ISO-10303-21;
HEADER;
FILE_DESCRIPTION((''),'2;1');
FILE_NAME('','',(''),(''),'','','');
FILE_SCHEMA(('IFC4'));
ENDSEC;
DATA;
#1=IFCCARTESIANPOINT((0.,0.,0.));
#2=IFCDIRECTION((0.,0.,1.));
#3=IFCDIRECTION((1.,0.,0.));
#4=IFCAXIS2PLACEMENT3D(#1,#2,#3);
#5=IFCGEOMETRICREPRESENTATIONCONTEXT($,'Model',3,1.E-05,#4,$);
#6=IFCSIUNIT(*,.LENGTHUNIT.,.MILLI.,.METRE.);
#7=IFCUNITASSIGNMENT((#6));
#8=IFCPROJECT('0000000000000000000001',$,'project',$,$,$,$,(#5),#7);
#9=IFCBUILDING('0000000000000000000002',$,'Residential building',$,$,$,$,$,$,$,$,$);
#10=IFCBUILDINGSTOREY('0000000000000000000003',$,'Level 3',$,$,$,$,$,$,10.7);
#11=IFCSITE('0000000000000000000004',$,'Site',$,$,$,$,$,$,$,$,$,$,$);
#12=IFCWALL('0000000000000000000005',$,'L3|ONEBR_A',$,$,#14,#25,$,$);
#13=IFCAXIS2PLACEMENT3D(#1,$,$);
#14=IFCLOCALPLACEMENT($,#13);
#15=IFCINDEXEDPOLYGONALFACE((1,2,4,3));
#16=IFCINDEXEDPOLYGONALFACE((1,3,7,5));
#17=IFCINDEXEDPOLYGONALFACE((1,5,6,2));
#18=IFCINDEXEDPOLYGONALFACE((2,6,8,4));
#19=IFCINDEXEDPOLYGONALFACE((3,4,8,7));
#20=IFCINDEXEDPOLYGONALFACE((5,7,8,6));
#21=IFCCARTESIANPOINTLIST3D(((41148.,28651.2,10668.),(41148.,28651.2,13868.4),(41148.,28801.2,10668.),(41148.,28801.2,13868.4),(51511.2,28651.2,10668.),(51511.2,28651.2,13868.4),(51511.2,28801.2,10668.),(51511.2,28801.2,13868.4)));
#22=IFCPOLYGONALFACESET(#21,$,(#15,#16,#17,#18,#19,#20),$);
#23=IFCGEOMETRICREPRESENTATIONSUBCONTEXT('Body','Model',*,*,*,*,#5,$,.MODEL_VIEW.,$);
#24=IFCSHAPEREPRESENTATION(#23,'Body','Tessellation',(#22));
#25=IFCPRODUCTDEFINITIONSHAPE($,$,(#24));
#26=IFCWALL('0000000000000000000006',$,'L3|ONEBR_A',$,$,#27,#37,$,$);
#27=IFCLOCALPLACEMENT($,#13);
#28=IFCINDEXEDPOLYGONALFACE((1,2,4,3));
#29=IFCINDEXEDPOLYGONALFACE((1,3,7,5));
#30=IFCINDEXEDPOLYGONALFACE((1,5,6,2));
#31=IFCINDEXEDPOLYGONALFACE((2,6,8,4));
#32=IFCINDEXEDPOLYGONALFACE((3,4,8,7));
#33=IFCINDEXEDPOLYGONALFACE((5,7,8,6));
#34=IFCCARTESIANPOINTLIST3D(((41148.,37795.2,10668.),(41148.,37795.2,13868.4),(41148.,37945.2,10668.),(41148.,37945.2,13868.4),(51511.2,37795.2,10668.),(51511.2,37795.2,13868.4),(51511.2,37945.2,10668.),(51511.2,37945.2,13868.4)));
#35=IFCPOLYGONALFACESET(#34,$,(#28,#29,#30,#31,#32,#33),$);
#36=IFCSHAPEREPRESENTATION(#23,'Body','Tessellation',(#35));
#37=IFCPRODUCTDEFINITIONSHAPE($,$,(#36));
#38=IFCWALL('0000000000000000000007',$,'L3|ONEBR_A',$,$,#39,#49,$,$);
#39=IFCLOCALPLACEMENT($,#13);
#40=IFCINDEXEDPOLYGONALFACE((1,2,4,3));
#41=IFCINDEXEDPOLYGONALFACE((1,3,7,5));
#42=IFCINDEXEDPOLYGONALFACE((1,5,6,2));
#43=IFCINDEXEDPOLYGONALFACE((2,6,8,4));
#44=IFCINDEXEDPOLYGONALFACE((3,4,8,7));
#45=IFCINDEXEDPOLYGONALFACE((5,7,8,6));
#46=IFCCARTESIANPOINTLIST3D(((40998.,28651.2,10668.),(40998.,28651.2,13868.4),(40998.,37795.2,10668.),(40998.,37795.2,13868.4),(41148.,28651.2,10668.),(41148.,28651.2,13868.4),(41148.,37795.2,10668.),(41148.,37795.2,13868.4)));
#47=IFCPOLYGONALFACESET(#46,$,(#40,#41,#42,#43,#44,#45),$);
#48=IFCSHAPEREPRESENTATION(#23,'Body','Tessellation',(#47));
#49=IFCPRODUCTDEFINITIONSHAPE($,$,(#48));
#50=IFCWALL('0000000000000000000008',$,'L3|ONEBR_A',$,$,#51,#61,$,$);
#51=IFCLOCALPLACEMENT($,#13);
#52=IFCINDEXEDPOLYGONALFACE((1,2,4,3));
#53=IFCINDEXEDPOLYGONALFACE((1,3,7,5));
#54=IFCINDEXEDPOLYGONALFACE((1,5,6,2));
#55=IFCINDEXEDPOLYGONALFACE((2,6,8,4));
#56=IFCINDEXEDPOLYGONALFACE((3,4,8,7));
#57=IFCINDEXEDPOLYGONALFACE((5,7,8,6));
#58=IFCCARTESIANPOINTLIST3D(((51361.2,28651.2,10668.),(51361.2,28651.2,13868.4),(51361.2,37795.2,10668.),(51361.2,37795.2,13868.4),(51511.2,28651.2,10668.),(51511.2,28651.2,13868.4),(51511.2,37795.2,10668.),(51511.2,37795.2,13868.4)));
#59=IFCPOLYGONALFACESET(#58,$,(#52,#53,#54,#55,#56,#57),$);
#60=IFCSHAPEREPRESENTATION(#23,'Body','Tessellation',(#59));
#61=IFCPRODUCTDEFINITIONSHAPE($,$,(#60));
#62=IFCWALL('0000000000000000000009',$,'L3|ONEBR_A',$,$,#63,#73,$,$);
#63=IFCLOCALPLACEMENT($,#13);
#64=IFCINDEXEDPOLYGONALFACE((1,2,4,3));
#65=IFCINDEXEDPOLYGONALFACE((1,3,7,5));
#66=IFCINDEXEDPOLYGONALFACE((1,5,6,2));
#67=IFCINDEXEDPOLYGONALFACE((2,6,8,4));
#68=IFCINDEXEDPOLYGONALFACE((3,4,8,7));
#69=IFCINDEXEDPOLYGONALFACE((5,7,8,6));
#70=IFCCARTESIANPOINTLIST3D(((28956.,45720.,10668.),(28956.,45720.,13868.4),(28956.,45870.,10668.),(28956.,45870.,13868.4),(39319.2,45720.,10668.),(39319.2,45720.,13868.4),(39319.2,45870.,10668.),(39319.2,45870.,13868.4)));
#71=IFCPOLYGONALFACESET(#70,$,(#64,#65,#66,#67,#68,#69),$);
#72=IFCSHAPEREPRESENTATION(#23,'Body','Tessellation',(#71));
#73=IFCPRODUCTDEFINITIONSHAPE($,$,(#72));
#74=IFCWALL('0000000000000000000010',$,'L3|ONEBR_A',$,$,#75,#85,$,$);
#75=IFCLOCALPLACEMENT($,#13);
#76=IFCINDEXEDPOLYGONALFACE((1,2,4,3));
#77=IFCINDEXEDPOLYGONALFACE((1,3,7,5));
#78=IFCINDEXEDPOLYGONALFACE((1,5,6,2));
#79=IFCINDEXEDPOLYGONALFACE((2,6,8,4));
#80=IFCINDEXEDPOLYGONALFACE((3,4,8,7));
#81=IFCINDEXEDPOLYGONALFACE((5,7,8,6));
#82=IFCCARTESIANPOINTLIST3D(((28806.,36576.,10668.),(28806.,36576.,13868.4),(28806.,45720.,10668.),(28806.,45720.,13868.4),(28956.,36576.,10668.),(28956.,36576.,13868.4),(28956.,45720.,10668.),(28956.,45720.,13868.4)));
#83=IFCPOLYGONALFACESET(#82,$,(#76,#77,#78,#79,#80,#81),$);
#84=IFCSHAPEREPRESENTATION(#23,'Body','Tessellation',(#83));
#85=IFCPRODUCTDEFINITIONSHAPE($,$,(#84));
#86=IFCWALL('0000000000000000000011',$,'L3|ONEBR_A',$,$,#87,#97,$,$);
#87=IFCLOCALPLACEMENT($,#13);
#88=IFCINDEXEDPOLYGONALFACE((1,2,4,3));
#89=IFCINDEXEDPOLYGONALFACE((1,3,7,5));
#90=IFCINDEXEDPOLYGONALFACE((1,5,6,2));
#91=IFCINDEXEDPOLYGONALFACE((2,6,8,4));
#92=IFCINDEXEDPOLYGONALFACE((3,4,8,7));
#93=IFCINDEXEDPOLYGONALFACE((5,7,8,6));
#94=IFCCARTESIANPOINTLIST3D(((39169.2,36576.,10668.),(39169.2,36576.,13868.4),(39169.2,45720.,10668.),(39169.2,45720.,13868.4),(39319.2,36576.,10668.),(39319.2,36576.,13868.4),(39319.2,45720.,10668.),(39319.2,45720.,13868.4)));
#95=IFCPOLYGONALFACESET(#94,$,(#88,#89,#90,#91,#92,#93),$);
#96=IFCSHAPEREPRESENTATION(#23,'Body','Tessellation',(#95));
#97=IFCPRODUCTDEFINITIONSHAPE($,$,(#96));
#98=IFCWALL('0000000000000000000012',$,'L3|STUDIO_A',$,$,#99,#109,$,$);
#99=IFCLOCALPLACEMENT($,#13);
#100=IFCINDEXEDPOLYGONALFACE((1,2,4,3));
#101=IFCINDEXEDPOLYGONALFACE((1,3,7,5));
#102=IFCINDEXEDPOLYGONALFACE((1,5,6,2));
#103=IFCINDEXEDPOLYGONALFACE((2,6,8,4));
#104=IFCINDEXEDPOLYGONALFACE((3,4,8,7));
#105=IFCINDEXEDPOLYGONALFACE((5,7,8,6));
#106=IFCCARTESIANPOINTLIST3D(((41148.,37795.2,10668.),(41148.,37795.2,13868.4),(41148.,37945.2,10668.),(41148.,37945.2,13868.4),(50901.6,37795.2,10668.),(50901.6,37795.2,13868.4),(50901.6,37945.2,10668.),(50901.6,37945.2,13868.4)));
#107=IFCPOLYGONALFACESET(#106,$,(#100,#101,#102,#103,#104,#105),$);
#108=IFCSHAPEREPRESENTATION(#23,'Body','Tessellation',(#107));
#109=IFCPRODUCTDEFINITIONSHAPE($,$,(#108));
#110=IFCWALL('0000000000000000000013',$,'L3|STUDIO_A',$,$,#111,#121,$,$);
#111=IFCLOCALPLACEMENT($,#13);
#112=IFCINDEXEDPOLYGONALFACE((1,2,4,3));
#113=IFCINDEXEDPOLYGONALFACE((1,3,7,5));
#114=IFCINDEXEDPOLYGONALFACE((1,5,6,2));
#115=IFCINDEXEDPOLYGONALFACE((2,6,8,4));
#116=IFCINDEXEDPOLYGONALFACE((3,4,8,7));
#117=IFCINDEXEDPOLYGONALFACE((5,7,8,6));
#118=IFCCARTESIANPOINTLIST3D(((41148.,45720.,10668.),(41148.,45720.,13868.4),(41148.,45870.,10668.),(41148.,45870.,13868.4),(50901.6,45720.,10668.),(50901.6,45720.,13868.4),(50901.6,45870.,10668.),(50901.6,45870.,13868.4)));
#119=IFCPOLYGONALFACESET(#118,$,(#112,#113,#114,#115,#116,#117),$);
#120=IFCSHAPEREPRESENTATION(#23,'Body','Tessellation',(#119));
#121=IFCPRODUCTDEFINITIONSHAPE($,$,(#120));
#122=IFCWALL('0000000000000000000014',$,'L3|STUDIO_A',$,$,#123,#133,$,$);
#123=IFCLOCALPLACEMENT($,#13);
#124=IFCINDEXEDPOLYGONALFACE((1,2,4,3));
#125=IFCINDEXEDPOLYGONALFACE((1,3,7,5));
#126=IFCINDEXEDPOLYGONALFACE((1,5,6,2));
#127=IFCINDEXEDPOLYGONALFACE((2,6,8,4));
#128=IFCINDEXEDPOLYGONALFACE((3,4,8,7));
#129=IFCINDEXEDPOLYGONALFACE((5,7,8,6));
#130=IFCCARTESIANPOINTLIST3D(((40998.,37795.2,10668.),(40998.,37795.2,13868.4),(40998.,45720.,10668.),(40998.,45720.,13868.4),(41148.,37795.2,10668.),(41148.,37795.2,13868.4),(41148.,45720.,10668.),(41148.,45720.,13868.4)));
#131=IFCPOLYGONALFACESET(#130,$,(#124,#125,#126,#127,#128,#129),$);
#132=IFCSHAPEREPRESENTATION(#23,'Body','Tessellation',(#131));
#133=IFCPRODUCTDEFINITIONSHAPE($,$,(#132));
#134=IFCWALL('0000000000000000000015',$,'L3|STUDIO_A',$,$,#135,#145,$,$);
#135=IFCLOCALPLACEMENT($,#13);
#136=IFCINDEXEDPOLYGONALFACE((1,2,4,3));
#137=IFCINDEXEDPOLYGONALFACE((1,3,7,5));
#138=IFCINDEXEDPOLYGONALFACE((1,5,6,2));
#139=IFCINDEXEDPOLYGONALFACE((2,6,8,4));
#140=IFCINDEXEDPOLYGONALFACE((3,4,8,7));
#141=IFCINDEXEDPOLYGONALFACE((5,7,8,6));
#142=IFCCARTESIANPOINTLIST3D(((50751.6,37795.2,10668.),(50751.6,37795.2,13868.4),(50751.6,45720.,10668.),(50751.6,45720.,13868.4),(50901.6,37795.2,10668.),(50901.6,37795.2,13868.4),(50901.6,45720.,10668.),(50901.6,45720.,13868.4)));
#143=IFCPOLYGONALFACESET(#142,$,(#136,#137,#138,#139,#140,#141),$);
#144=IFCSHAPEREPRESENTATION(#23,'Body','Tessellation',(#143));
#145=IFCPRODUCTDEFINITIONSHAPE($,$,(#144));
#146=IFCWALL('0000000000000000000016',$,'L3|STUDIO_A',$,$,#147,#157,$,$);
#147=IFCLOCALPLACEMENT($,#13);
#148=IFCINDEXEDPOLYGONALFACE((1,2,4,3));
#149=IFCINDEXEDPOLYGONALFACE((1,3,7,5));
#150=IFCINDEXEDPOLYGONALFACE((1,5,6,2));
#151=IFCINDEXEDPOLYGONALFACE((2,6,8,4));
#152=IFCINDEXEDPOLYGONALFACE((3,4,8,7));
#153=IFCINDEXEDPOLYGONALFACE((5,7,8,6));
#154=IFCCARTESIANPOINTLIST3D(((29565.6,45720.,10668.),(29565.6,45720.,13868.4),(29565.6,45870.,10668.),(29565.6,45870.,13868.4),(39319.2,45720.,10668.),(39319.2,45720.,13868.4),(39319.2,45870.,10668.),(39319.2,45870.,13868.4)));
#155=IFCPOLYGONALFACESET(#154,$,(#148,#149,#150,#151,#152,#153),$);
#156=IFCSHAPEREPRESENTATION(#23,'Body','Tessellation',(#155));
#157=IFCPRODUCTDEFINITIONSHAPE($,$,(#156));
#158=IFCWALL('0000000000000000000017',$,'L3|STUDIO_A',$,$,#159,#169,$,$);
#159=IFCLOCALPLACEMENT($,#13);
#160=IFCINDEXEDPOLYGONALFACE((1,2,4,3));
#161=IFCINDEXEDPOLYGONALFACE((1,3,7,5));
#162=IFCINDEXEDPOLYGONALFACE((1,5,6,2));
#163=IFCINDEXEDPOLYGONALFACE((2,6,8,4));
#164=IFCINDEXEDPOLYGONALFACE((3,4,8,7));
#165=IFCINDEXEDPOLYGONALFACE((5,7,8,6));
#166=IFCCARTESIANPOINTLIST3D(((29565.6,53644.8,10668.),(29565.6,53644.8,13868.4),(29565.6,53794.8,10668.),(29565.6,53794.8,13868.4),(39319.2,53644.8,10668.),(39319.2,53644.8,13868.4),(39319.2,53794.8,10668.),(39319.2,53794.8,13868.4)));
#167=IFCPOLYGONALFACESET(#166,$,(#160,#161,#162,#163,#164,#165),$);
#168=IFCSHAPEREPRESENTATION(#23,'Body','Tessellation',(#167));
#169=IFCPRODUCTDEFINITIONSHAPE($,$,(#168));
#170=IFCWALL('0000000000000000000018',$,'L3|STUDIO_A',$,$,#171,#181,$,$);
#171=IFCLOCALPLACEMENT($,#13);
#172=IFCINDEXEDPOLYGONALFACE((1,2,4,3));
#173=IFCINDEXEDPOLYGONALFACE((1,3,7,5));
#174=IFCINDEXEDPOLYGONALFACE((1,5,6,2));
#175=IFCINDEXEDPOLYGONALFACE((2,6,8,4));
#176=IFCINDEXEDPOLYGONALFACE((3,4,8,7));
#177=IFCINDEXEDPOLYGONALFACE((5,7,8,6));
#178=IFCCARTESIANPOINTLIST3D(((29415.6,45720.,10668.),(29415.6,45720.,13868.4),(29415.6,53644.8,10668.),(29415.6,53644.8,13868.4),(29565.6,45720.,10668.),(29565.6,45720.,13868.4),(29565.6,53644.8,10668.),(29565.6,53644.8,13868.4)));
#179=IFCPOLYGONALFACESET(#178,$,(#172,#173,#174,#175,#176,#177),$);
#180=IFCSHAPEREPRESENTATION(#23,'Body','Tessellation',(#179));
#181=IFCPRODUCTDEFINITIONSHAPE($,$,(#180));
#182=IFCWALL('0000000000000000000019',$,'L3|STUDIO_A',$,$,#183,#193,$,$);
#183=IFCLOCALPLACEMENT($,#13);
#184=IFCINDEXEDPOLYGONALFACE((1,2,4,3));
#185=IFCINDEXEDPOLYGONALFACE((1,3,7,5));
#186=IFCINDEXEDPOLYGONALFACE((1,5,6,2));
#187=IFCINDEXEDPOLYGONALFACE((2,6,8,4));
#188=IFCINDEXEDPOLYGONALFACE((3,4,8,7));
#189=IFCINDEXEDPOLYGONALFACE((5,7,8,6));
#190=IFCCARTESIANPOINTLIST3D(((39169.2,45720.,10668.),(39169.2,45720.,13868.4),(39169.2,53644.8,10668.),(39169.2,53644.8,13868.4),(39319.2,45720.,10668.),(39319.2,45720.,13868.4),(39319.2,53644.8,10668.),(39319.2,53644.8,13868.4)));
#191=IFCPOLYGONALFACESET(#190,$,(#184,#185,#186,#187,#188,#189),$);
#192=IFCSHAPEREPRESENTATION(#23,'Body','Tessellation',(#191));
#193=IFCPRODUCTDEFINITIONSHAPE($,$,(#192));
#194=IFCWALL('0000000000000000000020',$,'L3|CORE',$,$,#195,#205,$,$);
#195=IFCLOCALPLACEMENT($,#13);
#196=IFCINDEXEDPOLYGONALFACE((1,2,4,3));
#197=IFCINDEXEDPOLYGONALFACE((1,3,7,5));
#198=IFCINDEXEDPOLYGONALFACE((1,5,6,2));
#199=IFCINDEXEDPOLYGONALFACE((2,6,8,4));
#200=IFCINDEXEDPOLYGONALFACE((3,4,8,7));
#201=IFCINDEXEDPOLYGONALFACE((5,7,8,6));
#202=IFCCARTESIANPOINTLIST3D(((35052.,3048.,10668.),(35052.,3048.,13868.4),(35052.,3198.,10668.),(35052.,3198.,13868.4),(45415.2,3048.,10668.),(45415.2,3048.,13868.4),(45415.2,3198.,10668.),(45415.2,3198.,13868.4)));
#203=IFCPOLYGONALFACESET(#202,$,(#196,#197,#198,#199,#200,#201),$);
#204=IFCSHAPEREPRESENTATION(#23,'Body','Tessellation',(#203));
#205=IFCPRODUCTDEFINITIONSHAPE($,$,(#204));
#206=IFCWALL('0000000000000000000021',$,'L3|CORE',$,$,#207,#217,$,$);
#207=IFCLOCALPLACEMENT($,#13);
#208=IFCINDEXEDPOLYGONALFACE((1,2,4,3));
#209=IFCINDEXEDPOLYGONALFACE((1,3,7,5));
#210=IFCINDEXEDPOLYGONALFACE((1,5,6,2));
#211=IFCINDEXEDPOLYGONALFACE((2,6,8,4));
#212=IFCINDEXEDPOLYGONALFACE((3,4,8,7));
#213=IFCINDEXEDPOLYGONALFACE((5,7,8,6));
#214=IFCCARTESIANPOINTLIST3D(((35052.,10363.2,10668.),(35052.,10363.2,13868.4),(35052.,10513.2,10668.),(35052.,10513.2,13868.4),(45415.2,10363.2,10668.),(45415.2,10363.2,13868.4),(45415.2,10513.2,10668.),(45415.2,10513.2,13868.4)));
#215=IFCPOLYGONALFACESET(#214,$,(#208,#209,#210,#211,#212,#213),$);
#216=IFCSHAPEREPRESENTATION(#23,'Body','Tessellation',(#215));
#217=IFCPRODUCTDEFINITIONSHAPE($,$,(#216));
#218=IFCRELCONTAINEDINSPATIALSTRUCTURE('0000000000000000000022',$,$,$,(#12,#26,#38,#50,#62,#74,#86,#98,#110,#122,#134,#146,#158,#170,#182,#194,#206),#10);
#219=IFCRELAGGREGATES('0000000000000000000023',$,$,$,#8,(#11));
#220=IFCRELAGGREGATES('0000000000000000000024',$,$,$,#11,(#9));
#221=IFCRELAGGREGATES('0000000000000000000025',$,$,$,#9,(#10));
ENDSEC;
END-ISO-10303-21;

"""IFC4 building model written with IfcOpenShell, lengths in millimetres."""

from ifc_helpers import new_model, si_unit, frame, origin_with_axes, place, context, subcontext, project, spatial, indexed_curve, outline, extrude, element, save


model = new_model("IFC4")

# Units and contexts
model_context = context("Model", 3, precision=1e-05, world=origin_with_axes())
body_context = subcontext(model_context, "Body", "Model", "MODEL_VIEW")
ifc_project = project(units=[si_unit("LENGTHUNIT", "METRE", prefix="MILLI")], contexts=[model_context])

# Site, building, storey
site = spatial("IfcSite", under=ifc_project, Name="Site")
building = spatial("IfcBuilding", under=site, Name="Residential building")
storey = spatial("IfcBuildingStorey", under=building, Name="Level 3", Elevation=10.7)

# Walls
for number, where, z_axis, x_axis, name in (
    (1, (41148.0, 28651.2, 10668.0), (0.0, 0.0, 1.0), (1.0, 0.0, 0.0), "L3|ONEBR_A"),
    (2, (41148.0, 37795.2, 10668.0), (0.0, 0.0, 1.0), (1.0, 0.0, 0.0), "L3|ONEBR_A"),
):
    element("IfcWall", number, at=place(None, frame(where, z_axis=z_axis, x_axis=x_axis)), inside=storey, Name=name, context=body_context, shape_type="SweptSolid", body=[
        extrude(outline(indexed_curve([(0.0, 0.0), (0.0, 150.0), (10363.2, 150.0), (10363.2, 0.0), (0.0, 0.0)], self_intersect=False)), origin_with_axes(), (0.0, 0.0, 1.0), 3200.4),
    ])
for number, where, z_axis, x_axis, name in (
    (3, (41148.0, 28651.2, 10668.0), (0.0, 0.0, 1.0), (0.0, 1.0, 0.0), "L3|ONEBR_A"),
    (4, (51511.2, 28651.2, 10668.0), (0.0, 0.0, 1.0), (0.0, 1.0, 0.0), "L3|ONEBR_A"),
):
    element("IfcWall", number, at=place(None, frame(where, z_axis=z_axis, x_axis=x_axis)), inside=storey, Name=name, context=body_context, shape_type="SweptSolid", body=[
        extrude(outline(indexed_curve([(0.0, 0.0), (0.0, 150.0), (9144.0, 150.0), (9144.0, 0.0), (0.0, 0.0)], self_intersect=False)), origin_with_axes(), (0.0, 0.0, 1.0), 3200.4),
    ])
for number, where, z_axis, x_axis, name in (
    (5, (28956.0, 45720.0, 10668.0), (0.0, 0.0, 1.0), (1.0, 0.0, 0.0), "L3|ONEBR_A"),
):
    element("IfcWall", number, at=place(None, frame(where, z_axis=z_axis, x_axis=x_axis)), inside=storey, Name=name, context=body_context, shape_type="SweptSolid", body=[
        extrude(outline(indexed_curve([(0.0, 0.0), (0.0, 150.0), (10363.2, 150.0), (10363.2, 0.0), (0.0, 0.0)], self_intersect=False)), origin_with_axes(), (0.0, 0.0, 1.0), 3200.4),
    ])
for number, where, z_axis, x_axis, name in (
    (6, (28956.0, 36576.0, 10668.0), (0.0, 0.0, 1.0), (0.0, 1.0, 0.0), "L3|ONEBR_A"),
    (7, (39319.2, 36576.0, 10668.0), (0.0, 0.0, 1.0), (0.0, 1.0, 0.0), "L3|ONEBR_A"),
):
    element("IfcWall", number, at=place(None, frame(where, z_axis=z_axis, x_axis=x_axis)), inside=storey, Name=name, context=body_context, shape_type="SweptSolid", body=[
        extrude(outline(indexed_curve([(0.0, 0.0), (0.0, 150.0), (9144.0, 150.0), (9144.0, 0.0), (0.0, 0.0)], self_intersect=False)), origin_with_axes(), (0.0, 0.0, 1.0), 3200.4),
    ])
for number, where, z_axis, x_axis, name in (
    (8, (41148.0, 37795.2, 10668.0), (0.0, 0.0, 1.0), (1.0, 0.0, 0.0), "L3|STUDIO_A"),
    (9, (41148.0, 45720.0, 10668.0), (0.0, 0.0, 1.0), (1.0, 0.0, 0.0), "L3|STUDIO_A"),
):
    element("IfcWall", number, at=place(None, frame(where, z_axis=z_axis, x_axis=x_axis)), inside=storey, Name=name, context=body_context, shape_type="SweptSolid", body=[
        extrude(outline(indexed_curve([(0.0, 0.0), (0.0, 150.0), (9753.6, 150.0), (9753.6, 0.0), (0.0, 0.0)], self_intersect=False)), origin_with_axes(), (0.0, 0.0, 1.0), 3200.4),
    ])
for number, where, z_axis, x_axis, name in (
    (10, (41148.0, 37795.2, 10668.0), (0.0, 0.0, 1.0), (0.0, 1.0, 0.0), "L3|STUDIO_A"),
    (11, (50901.6, 37795.2, 10668.0), (0.0, 0.0, 1.0), (0.0, 1.0, 0.0), "L3|STUDIO_A"),
):
    element("IfcWall", number, at=place(None, frame(where, z_axis=z_axis, x_axis=x_axis)), inside=storey, Name=name, context=body_context, shape_type="SweptSolid", body=[
        extrude(outline(indexed_curve([(0.0, 0.0), (0.0, 150.0), (7924.8, 150.0), (7924.8, 0.0), (0.0, 0.0)], self_intersect=False)), origin_with_axes(), (0.0, 0.0, 1.0), 3200.4),
    ])
for number, where, z_axis, x_axis, name in (
    (12, (29565.6, 45720.0, 10668.0), (0.0, 0.0, 1.0), (1.0, 0.0, 0.0), "L3|STUDIO_A"),
    (13, (29565.6, 53644.8, 10668.0), (0.0, 0.0, 1.0), (1.0, 0.0, 0.0), "L3|STUDIO_A"),
):
    element("IfcWall", number, at=place(None, frame(where, z_axis=z_axis, x_axis=x_axis)), inside=storey, Name=name, context=body_context, shape_type="SweptSolid", body=[
        extrude(outline(indexed_curve([(0.0, 0.0), (0.0, 150.0), (9753.6, 150.0), (9753.6, 0.0), (0.0, 0.0)], self_intersect=False)), origin_with_axes(), (0.0, 0.0, 1.0), 3200.4),
    ])
for number, where, z_axis, x_axis, name in (
    (14, (29565.6, 45720.0, 10668.0), (0.0, 0.0, 1.0), (0.0, 1.0, 0.0), "L3|STUDIO_A"),
    (15, (39319.2, 45720.0, 10668.0), (0.0, 0.0, 1.0), (0.0, 1.0, 0.0), "L3|STUDIO_A"),
):
    element("IfcWall", number, at=place(None, frame(where, z_axis=z_axis, x_axis=x_axis)), inside=storey, Name=name, context=body_context, shape_type="SweptSolid", body=[
        extrude(outline(indexed_curve([(0.0, 0.0), (0.0, 150.0), (7924.8, 150.0), (7924.8, 0.0), (0.0, 0.0)], self_intersect=False)), origin_with_axes(), (0.0, 0.0, 1.0), 3200.4),
    ])
for number, where, z_axis, x_axis, name in (
    (16, (35052.0, 3048.0, 10668.0), (0.0, 0.0, 1.0), (1.0, 0.0, 0.0), "L3|CORE"),
    (17, (35052.0, 10363.2, 10668.0), (0.0, 0.0, 1.0), (1.0, 0.0, 0.0), "L3|CORE"),
):
    element("IfcWall", number, at=place(None, frame(where, z_axis=z_axis, x_axis=x_axis)), inside=storey, Name=name, context=body_context, shape_type="SweptSolid", body=[
        extrude(outline(indexed_curve([(0.0, 0.0), (0.0, 150.0), (10363.2, 150.0), (10363.2, 0.0), (0.0, 0.0)], self_intersect=False)), origin_with_axes(), (0.0, 0.0, 1.0), 3200.4),
    ])

save(model, "model.ifc")
